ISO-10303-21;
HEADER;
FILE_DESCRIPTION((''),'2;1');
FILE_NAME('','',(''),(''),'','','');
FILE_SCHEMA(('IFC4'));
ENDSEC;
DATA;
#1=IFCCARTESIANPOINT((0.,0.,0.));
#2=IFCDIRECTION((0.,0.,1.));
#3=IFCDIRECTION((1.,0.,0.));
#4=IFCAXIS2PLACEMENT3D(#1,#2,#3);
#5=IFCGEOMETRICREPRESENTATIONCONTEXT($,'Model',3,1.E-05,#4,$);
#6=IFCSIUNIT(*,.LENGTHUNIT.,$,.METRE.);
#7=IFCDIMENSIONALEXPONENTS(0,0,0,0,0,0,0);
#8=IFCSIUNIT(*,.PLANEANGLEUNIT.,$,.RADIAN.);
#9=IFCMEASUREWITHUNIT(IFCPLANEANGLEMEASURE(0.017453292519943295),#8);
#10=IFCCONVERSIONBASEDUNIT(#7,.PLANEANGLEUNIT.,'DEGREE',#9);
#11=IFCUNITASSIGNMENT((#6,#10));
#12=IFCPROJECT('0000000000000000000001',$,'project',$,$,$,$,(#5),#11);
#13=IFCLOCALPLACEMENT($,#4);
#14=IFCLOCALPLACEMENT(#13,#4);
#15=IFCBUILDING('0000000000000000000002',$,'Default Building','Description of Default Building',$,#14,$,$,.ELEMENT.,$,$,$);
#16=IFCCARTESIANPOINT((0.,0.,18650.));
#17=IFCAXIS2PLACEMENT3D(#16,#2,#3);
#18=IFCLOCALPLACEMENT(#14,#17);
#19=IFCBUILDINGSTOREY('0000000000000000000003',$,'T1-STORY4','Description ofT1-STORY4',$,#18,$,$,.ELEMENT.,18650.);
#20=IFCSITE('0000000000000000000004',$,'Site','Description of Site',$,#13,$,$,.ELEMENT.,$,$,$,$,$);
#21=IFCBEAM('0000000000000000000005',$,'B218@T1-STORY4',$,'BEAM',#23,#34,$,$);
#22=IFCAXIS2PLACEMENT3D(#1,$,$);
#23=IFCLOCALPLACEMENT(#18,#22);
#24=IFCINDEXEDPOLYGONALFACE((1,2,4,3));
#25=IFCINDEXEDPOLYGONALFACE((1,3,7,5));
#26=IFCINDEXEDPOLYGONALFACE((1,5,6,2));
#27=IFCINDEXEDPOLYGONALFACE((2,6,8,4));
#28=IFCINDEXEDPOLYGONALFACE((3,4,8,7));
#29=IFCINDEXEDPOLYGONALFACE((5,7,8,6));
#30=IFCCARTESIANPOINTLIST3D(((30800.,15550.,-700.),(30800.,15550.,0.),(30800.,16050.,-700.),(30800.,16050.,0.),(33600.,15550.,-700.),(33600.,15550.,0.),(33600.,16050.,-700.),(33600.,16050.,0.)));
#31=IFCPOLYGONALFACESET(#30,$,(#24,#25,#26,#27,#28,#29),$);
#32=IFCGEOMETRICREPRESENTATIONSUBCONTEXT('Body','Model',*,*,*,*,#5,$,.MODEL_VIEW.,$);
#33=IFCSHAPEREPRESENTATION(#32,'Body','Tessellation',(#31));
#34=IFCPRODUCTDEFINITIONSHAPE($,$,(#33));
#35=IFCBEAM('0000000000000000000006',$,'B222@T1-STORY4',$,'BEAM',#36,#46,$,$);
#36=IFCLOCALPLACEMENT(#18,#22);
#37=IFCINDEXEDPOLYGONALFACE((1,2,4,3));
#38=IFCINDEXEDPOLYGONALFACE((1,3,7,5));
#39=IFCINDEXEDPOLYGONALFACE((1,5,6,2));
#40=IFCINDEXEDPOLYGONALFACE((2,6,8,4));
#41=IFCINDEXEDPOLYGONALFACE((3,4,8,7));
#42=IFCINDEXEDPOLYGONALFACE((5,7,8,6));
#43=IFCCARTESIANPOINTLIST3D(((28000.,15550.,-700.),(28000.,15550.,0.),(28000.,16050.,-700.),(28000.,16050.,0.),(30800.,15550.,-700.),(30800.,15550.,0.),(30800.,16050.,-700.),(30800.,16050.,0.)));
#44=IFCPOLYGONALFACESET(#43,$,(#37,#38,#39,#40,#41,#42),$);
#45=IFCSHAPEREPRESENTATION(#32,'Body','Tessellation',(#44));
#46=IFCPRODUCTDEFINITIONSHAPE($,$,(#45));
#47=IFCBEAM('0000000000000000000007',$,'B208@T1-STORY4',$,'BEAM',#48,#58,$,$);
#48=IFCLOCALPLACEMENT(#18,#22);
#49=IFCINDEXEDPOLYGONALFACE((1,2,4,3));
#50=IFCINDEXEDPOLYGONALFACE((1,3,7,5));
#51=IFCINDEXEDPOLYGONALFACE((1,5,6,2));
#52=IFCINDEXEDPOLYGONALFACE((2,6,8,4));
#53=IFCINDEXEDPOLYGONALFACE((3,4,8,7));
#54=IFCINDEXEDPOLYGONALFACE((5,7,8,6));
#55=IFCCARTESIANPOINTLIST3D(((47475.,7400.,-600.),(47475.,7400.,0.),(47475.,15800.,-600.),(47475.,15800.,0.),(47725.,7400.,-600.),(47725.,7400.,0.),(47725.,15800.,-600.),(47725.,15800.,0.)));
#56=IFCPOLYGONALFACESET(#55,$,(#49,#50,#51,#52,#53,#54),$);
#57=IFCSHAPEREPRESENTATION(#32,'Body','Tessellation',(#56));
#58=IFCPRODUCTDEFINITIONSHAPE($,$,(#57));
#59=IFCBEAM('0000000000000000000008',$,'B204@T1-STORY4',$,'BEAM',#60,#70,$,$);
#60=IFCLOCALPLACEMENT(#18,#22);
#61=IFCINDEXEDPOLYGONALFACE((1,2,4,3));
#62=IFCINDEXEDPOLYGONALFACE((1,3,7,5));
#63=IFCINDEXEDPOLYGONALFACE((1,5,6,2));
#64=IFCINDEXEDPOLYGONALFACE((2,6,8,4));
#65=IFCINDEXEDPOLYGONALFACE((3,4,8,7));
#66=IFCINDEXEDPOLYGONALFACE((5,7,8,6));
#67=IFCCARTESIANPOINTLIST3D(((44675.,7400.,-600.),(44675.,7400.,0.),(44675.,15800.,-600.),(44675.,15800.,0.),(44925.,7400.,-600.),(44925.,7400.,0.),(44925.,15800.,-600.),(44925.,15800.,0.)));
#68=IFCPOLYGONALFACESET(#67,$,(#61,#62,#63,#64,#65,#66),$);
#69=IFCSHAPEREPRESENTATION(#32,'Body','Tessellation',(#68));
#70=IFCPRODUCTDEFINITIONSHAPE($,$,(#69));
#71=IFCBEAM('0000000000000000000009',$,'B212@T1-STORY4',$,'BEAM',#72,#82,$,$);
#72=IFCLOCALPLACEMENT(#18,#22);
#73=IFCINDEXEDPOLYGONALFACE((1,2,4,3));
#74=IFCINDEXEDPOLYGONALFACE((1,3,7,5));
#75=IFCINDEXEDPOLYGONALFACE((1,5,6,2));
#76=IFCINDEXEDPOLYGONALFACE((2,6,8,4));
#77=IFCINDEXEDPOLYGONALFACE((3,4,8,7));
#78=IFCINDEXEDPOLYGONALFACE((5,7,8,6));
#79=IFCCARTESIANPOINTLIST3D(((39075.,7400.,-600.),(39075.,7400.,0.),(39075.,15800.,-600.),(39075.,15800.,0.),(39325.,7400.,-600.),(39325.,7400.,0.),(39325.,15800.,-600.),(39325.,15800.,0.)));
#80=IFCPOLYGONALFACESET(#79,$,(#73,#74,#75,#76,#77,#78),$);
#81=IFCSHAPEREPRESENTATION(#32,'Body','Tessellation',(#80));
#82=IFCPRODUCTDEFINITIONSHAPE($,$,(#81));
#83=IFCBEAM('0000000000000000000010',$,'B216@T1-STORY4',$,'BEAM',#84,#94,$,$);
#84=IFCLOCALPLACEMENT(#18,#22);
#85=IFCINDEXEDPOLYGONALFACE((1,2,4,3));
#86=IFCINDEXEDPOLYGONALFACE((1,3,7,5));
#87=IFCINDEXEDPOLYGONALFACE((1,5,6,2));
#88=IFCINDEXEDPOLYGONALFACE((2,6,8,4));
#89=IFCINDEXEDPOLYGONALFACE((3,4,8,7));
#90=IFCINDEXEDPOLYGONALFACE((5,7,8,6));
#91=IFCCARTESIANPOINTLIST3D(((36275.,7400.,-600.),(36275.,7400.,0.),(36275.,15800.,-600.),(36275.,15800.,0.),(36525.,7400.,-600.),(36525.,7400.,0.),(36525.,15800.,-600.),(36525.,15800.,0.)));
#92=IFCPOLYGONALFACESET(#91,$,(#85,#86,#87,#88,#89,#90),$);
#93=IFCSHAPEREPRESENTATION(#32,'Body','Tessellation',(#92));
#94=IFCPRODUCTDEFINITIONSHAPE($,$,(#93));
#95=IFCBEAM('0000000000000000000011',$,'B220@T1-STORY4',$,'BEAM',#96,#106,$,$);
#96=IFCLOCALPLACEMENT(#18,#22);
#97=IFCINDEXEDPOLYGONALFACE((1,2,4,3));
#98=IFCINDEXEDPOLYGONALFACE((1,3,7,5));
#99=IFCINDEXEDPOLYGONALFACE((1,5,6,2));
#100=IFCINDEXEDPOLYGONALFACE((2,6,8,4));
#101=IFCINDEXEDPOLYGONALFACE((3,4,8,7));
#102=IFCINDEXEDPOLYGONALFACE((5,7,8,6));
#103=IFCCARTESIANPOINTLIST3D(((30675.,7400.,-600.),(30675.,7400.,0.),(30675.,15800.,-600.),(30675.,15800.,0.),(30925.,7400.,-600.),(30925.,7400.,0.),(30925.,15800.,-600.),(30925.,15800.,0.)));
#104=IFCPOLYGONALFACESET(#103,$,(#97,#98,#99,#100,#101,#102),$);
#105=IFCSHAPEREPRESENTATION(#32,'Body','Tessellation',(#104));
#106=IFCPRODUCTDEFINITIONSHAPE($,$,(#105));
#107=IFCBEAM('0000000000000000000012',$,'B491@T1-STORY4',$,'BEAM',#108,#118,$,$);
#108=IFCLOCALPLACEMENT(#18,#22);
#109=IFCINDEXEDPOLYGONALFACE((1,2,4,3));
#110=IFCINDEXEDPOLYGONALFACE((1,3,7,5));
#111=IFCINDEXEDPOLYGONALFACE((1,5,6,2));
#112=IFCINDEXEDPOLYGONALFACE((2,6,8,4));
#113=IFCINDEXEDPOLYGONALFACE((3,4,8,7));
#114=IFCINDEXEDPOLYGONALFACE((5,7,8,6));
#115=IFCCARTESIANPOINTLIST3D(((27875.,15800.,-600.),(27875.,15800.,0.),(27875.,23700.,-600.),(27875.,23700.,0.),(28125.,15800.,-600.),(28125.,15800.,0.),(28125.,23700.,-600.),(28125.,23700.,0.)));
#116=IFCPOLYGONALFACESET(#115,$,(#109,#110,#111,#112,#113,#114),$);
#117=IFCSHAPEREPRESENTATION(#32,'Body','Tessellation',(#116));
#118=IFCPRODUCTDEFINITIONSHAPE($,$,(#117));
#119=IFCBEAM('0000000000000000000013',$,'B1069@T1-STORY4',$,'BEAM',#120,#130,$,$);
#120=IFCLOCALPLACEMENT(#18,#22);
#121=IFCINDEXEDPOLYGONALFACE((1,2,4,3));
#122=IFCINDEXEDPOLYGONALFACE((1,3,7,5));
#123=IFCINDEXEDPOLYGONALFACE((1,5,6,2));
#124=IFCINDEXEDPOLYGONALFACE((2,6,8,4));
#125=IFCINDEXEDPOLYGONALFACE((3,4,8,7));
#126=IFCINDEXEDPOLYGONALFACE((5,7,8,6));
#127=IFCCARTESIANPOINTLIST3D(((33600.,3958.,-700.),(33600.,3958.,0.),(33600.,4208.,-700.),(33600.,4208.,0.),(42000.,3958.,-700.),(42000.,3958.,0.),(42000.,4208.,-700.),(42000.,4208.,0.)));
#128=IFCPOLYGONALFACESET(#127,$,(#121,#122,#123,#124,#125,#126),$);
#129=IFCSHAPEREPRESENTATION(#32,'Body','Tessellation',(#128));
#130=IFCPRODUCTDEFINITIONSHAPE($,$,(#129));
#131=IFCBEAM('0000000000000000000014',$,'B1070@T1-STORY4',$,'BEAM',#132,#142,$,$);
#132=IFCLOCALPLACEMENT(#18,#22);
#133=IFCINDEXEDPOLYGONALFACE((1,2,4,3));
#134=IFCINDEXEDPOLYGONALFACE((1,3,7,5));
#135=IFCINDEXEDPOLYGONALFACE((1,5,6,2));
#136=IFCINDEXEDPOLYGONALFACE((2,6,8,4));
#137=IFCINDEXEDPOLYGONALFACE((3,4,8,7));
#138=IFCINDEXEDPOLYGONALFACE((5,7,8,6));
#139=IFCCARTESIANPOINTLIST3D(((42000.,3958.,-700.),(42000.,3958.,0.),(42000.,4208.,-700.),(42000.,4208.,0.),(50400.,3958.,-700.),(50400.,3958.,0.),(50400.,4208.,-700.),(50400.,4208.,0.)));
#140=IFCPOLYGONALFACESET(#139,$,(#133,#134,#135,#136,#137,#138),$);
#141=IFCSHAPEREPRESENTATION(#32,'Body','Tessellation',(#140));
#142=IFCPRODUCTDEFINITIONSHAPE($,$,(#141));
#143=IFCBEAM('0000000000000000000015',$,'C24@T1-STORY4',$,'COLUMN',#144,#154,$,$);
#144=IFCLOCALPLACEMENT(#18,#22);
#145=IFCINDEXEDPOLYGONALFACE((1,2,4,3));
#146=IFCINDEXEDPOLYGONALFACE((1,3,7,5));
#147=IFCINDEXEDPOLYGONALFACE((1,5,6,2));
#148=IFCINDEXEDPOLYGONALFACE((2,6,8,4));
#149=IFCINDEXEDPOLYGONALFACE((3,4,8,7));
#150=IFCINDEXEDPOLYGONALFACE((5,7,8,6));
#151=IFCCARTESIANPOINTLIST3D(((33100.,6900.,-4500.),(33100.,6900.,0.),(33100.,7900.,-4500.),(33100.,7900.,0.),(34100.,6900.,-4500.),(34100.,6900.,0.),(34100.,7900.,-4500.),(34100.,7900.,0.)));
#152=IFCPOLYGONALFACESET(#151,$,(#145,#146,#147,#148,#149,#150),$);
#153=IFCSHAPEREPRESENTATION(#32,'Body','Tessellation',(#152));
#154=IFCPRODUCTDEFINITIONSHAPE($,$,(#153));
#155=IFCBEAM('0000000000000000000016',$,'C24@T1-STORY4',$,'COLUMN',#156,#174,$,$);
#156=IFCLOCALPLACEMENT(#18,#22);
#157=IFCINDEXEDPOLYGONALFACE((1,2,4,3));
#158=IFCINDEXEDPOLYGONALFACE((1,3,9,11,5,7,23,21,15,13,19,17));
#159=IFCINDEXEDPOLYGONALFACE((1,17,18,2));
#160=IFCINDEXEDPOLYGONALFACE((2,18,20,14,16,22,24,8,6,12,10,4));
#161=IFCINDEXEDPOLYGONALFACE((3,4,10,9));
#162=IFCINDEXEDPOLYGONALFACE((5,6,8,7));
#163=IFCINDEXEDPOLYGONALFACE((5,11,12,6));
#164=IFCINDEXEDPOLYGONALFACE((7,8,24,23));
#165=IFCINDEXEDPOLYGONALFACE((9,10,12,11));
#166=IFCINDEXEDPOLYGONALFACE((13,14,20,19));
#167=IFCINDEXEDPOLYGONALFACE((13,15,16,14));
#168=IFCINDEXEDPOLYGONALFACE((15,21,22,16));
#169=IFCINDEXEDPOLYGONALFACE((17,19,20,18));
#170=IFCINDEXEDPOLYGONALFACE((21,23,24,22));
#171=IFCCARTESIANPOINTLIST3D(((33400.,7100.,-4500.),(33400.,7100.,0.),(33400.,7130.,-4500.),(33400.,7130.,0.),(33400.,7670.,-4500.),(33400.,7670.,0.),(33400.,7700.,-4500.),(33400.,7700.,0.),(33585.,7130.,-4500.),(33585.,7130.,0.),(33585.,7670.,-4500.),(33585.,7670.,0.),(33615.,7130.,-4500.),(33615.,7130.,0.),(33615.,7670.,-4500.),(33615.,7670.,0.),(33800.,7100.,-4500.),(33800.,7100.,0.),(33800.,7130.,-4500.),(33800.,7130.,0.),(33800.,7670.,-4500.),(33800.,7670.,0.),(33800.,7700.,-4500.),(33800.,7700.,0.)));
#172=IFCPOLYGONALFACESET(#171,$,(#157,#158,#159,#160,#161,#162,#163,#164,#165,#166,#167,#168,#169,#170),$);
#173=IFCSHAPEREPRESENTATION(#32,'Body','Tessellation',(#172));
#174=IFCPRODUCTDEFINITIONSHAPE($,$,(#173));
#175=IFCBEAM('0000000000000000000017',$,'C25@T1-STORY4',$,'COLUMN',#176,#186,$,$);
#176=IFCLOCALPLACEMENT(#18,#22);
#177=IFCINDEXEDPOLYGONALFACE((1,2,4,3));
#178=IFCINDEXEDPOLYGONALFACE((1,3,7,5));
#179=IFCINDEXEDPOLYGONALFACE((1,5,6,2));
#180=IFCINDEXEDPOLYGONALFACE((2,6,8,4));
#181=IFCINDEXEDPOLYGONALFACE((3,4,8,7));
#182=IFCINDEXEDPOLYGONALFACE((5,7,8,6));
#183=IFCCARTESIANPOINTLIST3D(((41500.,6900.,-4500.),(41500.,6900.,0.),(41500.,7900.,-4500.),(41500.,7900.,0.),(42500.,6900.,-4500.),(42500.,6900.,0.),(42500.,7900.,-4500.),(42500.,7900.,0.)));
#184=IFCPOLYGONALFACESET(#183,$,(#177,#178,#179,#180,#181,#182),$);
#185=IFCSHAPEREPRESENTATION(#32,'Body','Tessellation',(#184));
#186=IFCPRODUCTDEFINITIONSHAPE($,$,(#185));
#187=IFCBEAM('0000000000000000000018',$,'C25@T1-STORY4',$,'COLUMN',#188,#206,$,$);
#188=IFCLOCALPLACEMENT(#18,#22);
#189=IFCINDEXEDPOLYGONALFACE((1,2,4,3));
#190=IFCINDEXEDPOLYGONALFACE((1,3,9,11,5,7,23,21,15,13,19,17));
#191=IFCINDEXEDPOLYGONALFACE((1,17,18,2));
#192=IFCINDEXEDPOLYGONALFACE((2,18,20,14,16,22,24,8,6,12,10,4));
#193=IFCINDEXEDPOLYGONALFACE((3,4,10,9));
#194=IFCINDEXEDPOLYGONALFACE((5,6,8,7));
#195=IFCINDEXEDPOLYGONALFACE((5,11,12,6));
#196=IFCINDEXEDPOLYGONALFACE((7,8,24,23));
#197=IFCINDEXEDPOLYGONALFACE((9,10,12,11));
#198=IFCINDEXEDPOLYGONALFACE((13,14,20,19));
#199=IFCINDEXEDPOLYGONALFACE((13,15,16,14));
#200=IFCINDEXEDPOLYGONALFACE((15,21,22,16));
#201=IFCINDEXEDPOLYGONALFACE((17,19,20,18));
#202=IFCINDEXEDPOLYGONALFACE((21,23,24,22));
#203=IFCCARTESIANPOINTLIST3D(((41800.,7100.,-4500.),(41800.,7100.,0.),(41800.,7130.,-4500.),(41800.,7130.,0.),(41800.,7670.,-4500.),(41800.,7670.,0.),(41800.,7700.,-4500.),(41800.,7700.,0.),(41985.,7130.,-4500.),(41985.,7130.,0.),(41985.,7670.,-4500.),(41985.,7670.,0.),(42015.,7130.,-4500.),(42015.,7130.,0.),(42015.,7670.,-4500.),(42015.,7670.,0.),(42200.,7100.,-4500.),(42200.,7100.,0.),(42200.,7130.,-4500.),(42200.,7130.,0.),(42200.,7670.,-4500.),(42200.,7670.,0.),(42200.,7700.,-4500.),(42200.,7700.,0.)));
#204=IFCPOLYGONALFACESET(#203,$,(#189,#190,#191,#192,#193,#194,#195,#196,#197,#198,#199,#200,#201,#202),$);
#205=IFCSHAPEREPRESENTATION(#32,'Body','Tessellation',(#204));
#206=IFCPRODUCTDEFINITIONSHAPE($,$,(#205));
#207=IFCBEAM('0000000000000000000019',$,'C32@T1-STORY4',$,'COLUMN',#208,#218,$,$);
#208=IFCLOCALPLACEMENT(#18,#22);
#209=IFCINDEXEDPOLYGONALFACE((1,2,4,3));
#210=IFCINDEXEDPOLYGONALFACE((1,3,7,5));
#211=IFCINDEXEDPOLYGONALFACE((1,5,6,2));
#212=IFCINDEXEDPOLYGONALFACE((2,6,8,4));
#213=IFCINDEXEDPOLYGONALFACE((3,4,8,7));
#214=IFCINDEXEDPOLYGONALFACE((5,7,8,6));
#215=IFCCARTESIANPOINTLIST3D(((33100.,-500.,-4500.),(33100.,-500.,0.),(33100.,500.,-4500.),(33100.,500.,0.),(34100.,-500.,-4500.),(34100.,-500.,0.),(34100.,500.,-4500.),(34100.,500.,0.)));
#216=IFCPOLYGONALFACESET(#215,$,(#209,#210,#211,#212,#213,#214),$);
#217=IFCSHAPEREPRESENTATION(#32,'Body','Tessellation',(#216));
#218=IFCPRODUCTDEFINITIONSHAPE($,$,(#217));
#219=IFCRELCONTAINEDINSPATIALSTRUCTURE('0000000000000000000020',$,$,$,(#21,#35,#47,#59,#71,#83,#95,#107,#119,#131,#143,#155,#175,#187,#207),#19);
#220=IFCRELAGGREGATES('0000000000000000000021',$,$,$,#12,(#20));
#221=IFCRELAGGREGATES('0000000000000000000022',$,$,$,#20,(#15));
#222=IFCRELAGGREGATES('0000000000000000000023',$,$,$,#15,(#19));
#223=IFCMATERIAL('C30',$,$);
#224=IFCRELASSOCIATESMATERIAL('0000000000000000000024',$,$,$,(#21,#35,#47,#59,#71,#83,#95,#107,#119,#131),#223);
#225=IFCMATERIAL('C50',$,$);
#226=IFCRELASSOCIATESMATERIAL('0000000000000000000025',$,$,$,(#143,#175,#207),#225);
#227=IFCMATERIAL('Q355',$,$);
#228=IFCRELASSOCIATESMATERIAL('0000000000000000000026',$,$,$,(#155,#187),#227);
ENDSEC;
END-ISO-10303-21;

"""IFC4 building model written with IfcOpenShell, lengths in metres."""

from ifc_helpers import new_model, entity, si_unit, converted_unit, frame, origin_with_axes, place, context, subcontext, project, spatial, rectangle, i_section, extrude, material, element, save


model = new_model("IFC4")

# Units and contexts
model_context = context("Model", 3, precision=1e-05, world=origin_with_axes())
body_context = subcontext(model_context, "Body", "Model", "MODEL_VIEW")
ifc_project = project(units=[si_unit("LENGTHUNIT", "METRE"), converted_unit("PLANEANGLEUNIT", "DEGREE", entity("IfcPlaneAngleMeasure", 0.017453292519943295), si_unit("PLANEANGLEUNIT", "RADIAN"), dimensions=[0, 0, 0, 0, 0, 0, 0])], contexts=[model_context])

# Site, building, storey
site_placement = place(None, origin_with_axes())
site = spatial("IfcSite", under=ifc_project, at=site_placement, Name="Site", Description="Description of Site", CompositionType="ELEMENT")
building_placement = place(site_placement, origin_with_axes())
building = spatial("IfcBuilding", under=site, at=building_placement, Name="Default Building", Description="Description of Default Building", CompositionType="ELEMENT")
storey_placement = place(building_placement, frame((0.0, 0.0, 18650.0), z_axis=(0.0, 0.0, 1.0), x_axis=(1.0, 0.0, 0.0)))
storey = spatial("IfcBuildingStorey", under=building, at=storey_placement, Name="T1-STORY4", Description="Description ofT1-STORY4", CompositionType="ELEMENT", Elevation=18650.0)

# Beams
ifc_material_1 = material(Name="C30")
for number, where, z_axis, x_axis, name in (
    (1, (30800.0, 15800.0, -350.0), (1.0, 0.0, 0.0), (0.0, 1.0, 0.0), "B218@T1-STORY4"),
    (2, (28000.0, 15800.0, -350.0), (1.0, 0.0, 0.0), (0.0, 1.0, 0.0), "B222@T1-STORY4"),
):
    element("IfcBeam", number, at=place(storey_placement, frame(where, z_axis=z_axis, x_axis=x_axis)), inside=storey, material=ifc_material_1, Name=name, ObjectType="BEAM", context=body_context, shape_type="SweptSolid", body=[
        extrude(rectangle(XDim=500.0, YDim=700.0), origin_with_axes(), (0.0, 0.0, 1.0), 2800.0),
    ])
for number, where, z_axis, x_axis, name in (
    (3, (47600.0, 7400.0, -300.0), (0.0, 1.0, 0.0), (-1.0, 0.0, 0.0), "B208@T1-STORY4"),
    (4, (44800.0, 7400.0, -300.0), (0.0, 1.0, 0.0), (-1.0, 0.0, 0.0), "B204@T1-STORY4"),
    (5, (39200.0, 7400.0, -300.0), (0.0, 1.0, 0.0), (-1.0, 0.0, 0.0), "B212@T1-STORY4"),
    (6, (36400.0, 7400.0, -300.0), (0.0, 1.0, 0.0), (-1.0, 0.0, 0.0), "B216@T1-STORY4"),
    (7, (30800.0, 7400.0, -300.0), (0.0, 1.0, 0.0), (-1.0, 0.0, 0.0), "B220@T1-STORY4"),
):
    element("IfcBeam", number, at=place(storey_placement, frame(where, z_axis=z_axis, x_axis=x_axis)), inside=storey, material=ifc_material_1, Name=name, ObjectType="BEAM", context=body_context, shape_type="SweptSolid", body=[
        extrude(rectangle(XDim=250.0, YDim=600.0), origin_with_axes(), (0.0, 0.0, 1.0), 8400.0),
    ])
beam_1_placement = place(storey_placement, frame((28000.0, 15800.0, -300.0), z_axis=(0.0, 1.0, 0.0), x_axis=(-1.0, 0.0, 0.0)))
element("IfcBeam", 8, at=beam_1_placement, inside=storey, material=ifc_material_1, Name="B491@T1-STORY4", ObjectType="BEAM", context=body_context, shape_type="SweptSolid", body=[
    extrude(rectangle(XDim=250.0, YDim=600.0), origin_with_axes(), (0.0, 0.0, 1.0), 7900.0),
])
for number, where, z_axis, x_axis, name in (
    (9, (33600.0, 4083.0, -350.0), (1.0, 0.0, 0.0), (0.0, 1.0, 0.0), "B1069@T1-STORY4"),
    (10, (42000.0, 4083.0, -350.0), (1.0, 0.0, 0.0), (0.0, 1.0, 0.0), "B1070@T1-STORY4"),
):
    element("IfcBeam", number, at=place(storey_placement, frame(where, z_axis=z_axis, x_axis=x_axis)), inside=storey, material=ifc_material_1, Name=name, ObjectType="BEAM", context=body_context, shape_type="SweptSolid", body=[
        extrude(rectangle(XDim=250.0, YDim=700.0), origin_with_axes(), (0.0, 0.0, 1.0), 8400.0),
    ])
ifc_material_2 = material(Name="C50")
beam_2_placement = place(storey_placement, frame((33600.0, 7400.0, -4500.0), z_axis=(0.0, 0.0, 1.0), x_axis=(-1.0, 0.0, 0.0)))
element("IfcBeam", 11, at=beam_2_placement, inside=storey, material=ifc_material_2, Name="C24@T1-STORY4", ObjectType="COLUMN", context=body_context, shape_type="SweptSolid", body=[
    extrude(rectangle(XDim=1000.0, YDim=1000.0), origin_with_axes(), (0.0, 0.0, 1.0), 4500.0),
])
ifc_material_3 = material(Name="Q355")
beam_3_placement = place(storey_placement, frame((33600.0, 7400.0, -4500.0), z_axis=(0.0, 0.0, 1.0), x_axis=(-1.0, 0.0, 0.0)))
element("IfcBeam", 12, at=beam_3_placement, inside=storey, material=ifc_material_3, Name="C24@T1-STORY4", ObjectType="COLUMN", context=body_context, shape_type="SweptSolid", body=[
    extrude(i_section(OverallWidth=400.0, OverallDepth=600.0, WebThickness=30.0, FlangeThickness=30.0, FilletRadius=0.0), origin_with_axes(), (0.0, 0.0, 1.0), 4500.0),
])
beam_4_placement = place(storey_placement, frame((42000.0, 7400.0, -4500.0), z_axis=(0.0, 0.0, 1.0), x_axis=(-1.0, 0.0, 0.0)))
element("IfcBeam", 13, at=beam_4_placement, inside=storey, material=ifc_material_2, Name="C25@T1-STORY4", ObjectType="COLUMN", context=body_context, shape_type="SweptSolid", body=[
    extrude(rectangle(XDim=1000.0, YDim=1000.0), origin_with_axes(), (0.0, 0.0, 1.0), 4500.0),
])
beam_5_placement = place(storey_placement, frame((42000.0, 7400.0, -4500.0), z_axis=(0.0, 0.0, 1.0), x_axis=(-1.0, 0.0, 0.0)))
element("IfcBeam", 14, at=beam_5_placement, inside=storey, material=ifc_material_3, Name="C25@T1-STORY4", ObjectType="COLUMN", context=body_context, shape_type="SweptSolid", body=[
    extrude(i_section(OverallWidth=400.0, OverallDepth=600.0, WebThickness=30.0, FlangeThickness=30.0, FilletRadius=0.0), origin_with_axes(), (0.0, 0.0, 1.0), 4500.0),
])
beam_6_placement = place(storey_placement, frame((33600.0, 0.0, -4500.0), z_axis=(0.0, 0.0, 1.0), x_axis=(-1.0, 0.0, 0.0)))
element("IfcBeam", 15, at=beam_6_placement, inside=storey, material=ifc_material_2, Name="C32@T1-STORY4", ObjectType="COLUMN", context=body_context, shape_type="SweptSolid", body=[
    extrude(rectangle(XDim=1000.0, YDim=1000.0), origin_with_axes(), (0.0, 0.0, 1.0), 4500.0),
])

save(model, "model.ifc")
